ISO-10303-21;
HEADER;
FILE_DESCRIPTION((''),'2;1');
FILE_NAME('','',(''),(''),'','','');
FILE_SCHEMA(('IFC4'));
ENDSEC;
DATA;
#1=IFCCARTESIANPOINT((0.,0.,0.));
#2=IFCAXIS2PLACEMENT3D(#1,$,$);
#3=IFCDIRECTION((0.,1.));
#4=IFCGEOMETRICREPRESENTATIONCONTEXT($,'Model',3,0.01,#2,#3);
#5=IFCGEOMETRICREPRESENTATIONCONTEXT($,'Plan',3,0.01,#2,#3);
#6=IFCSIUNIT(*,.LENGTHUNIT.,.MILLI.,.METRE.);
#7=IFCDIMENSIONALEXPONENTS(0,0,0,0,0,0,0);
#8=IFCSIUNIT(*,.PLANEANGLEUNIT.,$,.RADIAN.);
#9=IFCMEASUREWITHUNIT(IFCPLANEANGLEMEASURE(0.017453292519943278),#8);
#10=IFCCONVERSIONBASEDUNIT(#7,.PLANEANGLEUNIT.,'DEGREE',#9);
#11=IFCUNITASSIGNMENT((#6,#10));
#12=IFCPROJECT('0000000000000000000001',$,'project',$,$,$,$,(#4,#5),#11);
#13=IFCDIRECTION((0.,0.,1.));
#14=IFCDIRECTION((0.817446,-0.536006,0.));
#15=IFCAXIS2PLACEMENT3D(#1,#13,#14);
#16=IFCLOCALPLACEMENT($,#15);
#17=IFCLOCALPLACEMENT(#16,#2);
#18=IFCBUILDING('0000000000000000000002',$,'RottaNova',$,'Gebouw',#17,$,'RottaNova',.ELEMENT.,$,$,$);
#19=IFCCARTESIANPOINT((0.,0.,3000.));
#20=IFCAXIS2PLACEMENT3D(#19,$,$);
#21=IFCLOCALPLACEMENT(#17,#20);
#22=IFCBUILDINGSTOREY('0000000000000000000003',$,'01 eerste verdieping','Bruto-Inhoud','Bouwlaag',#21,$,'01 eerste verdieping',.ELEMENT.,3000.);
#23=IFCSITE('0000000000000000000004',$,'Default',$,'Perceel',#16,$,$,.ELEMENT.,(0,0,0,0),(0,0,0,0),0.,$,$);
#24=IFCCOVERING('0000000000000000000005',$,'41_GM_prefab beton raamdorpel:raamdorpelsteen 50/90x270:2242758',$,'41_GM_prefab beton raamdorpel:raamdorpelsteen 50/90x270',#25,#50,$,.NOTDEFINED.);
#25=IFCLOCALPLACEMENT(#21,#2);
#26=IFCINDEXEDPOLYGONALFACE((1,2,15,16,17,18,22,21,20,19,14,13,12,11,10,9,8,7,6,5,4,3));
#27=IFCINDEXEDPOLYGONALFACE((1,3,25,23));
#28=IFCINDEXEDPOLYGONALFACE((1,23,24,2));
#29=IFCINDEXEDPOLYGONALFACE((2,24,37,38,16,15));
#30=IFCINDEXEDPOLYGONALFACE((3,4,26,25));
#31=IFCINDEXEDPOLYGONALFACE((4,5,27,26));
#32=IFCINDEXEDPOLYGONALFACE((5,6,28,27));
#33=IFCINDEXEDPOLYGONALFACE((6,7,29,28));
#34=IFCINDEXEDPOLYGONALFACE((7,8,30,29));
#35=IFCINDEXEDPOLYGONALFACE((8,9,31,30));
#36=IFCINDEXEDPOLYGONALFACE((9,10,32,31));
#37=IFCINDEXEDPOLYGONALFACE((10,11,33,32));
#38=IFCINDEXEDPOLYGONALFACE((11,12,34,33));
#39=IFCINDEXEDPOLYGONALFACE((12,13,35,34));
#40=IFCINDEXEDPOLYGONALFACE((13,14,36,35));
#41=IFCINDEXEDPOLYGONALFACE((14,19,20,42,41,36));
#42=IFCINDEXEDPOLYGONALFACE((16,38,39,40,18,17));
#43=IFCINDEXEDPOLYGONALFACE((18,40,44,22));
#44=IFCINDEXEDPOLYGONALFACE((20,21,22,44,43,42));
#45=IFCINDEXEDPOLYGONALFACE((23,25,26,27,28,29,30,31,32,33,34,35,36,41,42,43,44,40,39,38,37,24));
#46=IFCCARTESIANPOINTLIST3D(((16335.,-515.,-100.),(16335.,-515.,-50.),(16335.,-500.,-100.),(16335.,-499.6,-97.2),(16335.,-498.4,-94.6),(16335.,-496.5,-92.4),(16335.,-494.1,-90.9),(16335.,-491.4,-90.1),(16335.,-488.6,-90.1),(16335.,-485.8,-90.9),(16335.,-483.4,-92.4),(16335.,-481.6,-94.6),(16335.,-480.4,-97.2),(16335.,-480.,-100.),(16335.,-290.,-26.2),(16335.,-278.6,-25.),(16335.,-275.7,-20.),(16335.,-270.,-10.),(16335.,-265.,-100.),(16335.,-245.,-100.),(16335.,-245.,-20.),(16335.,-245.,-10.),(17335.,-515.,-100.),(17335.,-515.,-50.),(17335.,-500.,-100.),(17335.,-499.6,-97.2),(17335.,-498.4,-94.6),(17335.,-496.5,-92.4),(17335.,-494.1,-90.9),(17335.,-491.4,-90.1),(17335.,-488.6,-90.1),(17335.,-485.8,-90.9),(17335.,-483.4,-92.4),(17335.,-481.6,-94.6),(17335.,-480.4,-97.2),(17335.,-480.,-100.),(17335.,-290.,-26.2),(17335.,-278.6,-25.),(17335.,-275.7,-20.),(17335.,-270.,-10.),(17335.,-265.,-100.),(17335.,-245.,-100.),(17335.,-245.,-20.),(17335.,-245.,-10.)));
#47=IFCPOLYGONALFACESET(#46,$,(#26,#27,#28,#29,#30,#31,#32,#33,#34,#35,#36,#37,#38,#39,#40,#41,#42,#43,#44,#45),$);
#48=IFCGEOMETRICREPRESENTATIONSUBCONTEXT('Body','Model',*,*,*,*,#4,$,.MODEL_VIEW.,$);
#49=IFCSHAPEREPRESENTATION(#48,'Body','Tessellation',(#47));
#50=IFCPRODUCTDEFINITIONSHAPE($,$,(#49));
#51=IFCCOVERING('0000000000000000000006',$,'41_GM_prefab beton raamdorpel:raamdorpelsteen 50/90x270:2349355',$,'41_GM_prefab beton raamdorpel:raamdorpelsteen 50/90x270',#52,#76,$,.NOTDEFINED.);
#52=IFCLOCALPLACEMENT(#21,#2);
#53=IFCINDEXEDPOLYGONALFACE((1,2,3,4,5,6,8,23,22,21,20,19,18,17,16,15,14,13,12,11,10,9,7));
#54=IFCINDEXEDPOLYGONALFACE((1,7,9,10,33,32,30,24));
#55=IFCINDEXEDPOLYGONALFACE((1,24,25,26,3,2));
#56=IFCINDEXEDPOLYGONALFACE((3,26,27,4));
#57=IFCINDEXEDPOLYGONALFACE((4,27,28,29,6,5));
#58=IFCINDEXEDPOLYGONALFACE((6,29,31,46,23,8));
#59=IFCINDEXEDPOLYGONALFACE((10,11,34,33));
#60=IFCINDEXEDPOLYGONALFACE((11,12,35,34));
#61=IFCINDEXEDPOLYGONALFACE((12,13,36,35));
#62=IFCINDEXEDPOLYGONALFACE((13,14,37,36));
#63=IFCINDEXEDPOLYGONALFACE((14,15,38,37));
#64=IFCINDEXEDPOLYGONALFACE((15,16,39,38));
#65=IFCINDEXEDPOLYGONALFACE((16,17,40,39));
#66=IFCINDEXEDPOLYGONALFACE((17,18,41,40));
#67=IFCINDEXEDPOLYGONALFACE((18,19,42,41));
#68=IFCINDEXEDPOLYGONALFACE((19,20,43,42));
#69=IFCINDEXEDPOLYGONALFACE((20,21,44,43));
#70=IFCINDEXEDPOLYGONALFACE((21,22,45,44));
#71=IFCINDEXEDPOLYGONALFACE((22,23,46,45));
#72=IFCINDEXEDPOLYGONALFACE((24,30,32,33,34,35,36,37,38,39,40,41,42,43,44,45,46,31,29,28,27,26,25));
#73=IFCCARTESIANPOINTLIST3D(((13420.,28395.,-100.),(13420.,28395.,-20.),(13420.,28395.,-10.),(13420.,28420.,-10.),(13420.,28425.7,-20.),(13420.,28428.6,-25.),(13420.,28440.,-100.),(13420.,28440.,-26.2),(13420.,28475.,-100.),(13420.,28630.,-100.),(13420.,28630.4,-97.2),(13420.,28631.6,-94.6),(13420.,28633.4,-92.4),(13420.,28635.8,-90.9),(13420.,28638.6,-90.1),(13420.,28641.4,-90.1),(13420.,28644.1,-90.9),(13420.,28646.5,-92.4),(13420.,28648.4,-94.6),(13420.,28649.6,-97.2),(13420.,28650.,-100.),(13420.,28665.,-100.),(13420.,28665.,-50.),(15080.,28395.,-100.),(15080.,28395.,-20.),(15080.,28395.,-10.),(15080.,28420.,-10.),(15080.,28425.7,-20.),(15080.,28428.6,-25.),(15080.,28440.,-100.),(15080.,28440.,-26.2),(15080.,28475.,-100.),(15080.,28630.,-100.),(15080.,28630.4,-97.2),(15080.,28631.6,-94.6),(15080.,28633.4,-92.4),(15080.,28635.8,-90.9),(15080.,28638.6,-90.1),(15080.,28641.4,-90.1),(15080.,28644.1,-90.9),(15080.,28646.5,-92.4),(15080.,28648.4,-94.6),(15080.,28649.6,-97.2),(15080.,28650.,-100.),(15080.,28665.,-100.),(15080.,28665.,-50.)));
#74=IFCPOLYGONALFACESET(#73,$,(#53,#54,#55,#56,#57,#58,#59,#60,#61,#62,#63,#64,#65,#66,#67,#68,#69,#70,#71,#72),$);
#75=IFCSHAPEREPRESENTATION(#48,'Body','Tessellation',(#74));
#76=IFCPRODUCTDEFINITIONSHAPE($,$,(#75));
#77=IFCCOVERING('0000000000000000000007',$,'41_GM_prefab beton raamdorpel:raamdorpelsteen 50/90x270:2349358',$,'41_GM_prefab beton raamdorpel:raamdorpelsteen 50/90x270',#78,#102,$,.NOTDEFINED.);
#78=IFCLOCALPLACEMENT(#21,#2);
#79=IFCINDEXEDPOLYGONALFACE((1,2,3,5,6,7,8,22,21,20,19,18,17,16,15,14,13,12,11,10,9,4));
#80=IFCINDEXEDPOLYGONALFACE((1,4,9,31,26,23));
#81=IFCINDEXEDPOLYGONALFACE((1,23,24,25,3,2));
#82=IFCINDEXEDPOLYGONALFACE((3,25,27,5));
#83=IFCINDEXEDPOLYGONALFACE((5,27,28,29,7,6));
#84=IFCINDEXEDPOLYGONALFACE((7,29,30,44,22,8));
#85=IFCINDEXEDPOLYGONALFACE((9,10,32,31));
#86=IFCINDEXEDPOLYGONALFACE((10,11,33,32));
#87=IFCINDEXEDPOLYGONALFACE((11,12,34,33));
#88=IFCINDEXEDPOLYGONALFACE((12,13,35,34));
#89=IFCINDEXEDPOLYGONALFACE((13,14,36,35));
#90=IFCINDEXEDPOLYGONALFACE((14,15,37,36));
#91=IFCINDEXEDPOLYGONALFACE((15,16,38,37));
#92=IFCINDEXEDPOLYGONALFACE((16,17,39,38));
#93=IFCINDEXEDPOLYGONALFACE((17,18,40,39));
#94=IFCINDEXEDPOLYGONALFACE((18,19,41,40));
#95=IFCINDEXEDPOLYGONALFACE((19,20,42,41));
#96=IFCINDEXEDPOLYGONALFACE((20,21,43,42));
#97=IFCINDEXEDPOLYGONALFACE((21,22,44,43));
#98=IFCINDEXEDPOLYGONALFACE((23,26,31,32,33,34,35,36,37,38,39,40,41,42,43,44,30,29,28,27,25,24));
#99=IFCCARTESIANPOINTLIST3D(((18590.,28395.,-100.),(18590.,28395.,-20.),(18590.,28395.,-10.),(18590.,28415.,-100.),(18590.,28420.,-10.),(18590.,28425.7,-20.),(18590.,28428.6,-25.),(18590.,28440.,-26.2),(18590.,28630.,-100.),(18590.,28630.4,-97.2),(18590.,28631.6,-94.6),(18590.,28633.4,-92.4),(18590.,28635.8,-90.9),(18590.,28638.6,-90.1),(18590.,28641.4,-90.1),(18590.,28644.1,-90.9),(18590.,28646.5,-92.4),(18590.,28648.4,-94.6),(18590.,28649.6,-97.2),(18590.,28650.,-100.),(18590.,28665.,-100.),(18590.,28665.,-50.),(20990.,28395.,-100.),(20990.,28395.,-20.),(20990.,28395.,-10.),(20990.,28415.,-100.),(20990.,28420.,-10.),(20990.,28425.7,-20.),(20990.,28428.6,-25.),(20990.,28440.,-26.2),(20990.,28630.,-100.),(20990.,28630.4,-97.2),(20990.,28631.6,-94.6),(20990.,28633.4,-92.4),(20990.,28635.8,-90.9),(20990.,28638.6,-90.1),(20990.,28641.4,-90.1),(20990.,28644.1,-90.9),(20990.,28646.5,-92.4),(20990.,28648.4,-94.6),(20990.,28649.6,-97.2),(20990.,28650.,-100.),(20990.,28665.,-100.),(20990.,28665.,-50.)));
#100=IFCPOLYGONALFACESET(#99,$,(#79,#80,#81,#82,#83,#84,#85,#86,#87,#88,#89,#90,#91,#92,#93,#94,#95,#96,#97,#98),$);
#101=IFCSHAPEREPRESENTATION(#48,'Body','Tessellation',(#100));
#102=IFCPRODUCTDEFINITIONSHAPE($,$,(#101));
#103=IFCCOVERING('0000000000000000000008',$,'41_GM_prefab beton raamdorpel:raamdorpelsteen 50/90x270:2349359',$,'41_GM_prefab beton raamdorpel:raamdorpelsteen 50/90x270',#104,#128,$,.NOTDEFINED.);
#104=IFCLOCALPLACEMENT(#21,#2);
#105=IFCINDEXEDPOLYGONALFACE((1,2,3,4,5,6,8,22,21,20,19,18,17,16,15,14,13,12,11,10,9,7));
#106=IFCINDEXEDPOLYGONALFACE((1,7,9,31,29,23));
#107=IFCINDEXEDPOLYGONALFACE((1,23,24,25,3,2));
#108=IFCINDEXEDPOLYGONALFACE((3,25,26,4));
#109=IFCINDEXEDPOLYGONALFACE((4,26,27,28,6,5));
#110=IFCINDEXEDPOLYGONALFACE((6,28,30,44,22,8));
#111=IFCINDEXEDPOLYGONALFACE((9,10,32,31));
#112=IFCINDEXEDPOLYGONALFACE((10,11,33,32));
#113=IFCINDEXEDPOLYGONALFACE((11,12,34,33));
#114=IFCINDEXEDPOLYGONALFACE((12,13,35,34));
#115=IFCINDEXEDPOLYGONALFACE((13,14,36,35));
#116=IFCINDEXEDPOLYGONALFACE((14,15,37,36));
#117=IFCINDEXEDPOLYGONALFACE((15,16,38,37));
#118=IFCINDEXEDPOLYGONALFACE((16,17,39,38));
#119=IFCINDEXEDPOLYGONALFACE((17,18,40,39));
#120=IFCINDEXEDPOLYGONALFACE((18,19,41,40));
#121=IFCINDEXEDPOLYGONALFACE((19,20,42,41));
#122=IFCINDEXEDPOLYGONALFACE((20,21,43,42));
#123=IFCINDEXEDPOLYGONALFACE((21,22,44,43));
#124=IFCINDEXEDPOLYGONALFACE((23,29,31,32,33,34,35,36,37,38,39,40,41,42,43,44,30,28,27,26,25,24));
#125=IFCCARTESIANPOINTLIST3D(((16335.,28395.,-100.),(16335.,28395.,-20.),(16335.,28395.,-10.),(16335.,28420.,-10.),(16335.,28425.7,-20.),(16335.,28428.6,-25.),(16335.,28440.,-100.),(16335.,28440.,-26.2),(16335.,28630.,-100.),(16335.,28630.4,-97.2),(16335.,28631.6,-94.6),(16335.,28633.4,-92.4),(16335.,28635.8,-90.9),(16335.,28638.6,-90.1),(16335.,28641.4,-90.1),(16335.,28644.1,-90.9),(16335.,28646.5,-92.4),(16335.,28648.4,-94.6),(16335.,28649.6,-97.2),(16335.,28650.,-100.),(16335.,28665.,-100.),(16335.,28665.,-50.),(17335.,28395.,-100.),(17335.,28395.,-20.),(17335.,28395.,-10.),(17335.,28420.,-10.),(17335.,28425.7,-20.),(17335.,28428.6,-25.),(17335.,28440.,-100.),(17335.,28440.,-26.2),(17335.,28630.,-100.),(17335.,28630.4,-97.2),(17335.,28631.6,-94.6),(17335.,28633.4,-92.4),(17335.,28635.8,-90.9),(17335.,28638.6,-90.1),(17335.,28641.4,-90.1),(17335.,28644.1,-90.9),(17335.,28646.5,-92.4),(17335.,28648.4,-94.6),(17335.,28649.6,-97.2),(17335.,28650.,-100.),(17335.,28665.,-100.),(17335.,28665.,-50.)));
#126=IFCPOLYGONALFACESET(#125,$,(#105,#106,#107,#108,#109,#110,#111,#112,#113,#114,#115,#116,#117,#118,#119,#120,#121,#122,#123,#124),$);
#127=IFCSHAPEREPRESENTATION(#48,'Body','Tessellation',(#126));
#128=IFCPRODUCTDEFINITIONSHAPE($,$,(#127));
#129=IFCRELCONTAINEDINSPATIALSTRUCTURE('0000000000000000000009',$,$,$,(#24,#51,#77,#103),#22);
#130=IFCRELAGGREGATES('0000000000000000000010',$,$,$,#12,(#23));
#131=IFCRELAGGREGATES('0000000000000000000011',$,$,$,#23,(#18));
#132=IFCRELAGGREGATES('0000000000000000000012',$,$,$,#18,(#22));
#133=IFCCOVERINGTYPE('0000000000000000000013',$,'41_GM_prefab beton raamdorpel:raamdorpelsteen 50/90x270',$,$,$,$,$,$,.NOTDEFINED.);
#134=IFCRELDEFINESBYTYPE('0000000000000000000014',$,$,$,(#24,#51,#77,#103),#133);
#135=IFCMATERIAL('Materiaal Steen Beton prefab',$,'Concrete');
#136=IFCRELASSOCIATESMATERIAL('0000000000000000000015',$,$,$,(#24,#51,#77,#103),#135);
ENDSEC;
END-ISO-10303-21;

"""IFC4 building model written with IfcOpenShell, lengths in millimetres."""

from ifc_helpers import new_model, entity, si_unit, converted_unit, direction, frame, origin, place, context, subcontext, project, spatial, line, arc, indexed_curve, outline, extrude, material, type_object, element, save


model = new_model("IFC4")

# Units and contexts
model_context = context("Model", 3, precision=0.01, world=origin(), true_north=direction((0.0, 1.0)))
plan_context = context("Plan", 3, precision=0.01, world=origin(), true_north=direction((0.0, 1.0)))
body_context = subcontext(model_context, "Body", "Model", "MODEL_VIEW")
ifc_project = project(units=[si_unit("LENGTHUNIT", "METRE", prefix="MILLI"), converted_unit("PLANEANGLEUNIT", "DEGREE", entity("IfcPlaneAngleMeasure", 0.017453292519943278), si_unit("PLANEANGLEUNIT", "RADIAN"), dimensions=[0, 0, 0, 0, 0, 0, 0])], contexts=[model_context, plan_context])

# Site, building, storey
site_placement = place(None, frame((0.0, 0.0, 0.0), z_axis=(0.0, 0.0, 1.0), x_axis=(0.817446, -0.536006, 0.0)))
site = spatial("IfcSite", under=ifc_project, at=site_placement, Name="Default", ObjectType="Perceel", CompositionType="ELEMENT", RefLatitude=(0, 0, 0, 0), RefLongitude=(0, 0, 0, 0), RefElevation=0.0)
building_placement = place(site_placement, origin())
building = spatial("IfcBuilding", under=site, at=building_placement, Name="RottaNova", ObjectType="Gebouw", LongName="RottaNova", CompositionType="ELEMENT")
storey_placement = place(building_placement, frame((0.0, 0.0, 3000.0)))
storey = spatial("IfcBuildingStorey", under=building, at=storey_placement, Name="01 eerste verdieping", Description="Bruto-Inhoud", ObjectType="Bouwlaag", LongName="01 eerste verdieping", CompositionType="ELEMENT", Elevation=3000.0)

# Shared definitions
ifc_material_1 = material(Name="Materiaal Steen Beton prefab", Category="Concrete")

# Coverings
covering_type_1 = type_object("IfcCoveringType", Name="41_GM_prefab beton raamdorpel:raamdorpelsteen 50/90x270", PredefinedType="NOTDEFINED")
covering_1_placement = place(storey_placement, origin())
element("IfcCovering", 1, at=covering_1_placement, inside=storey, type_object=covering_type_1, material=ifc_material_1, Name="41_GM_prefab beton raamdorpel:raamdorpelsteen 50/90x270:2242758", ObjectType="41_GM_prefab beton raamdorpel:raamdorpelsteen 50/90x270", PredefinedType="NOTDEFINED", context=body_context, shape_type="SweptSolid", body=[
    extrude(outline(indexed_curve([(-75.9, -41.3), (-88.4, -62.9), (-79.8, -67.9), (-10.5, -107.9), (-0.5, -90.6), (107.0, 95.6), (103.4, 109.3), (117.0, 112.9), (124.5, 125.9), (81.2, 150.9), (-51.9, -32.0), (-58.6, -41.3), (-64.4, -41.3)], segments=[line(1, 2, 3, 4, 5, 6), arc(6, 7, 8), line(8, 9, 10, 11, 12, 13, 1)], self_intersect=False)), frame((16335.0, -343.7, -55.1), z_axis=(-1.0, 0.0, 0.0), x_axis=(0.0, -0.5, -0.866025)), (0.0, 0.0, -1.0), 1000.0),
])
covering_2_placement = place(storey_placement, origin())
element("IfcCovering", 2, at=covering_2_placement, inside=storey, type_object=covering_type_1, material=ifc_material_1, Name="41_GM_prefab beton raamdorpel:raamdorpelsteen 50/90x270:2349355", ObjectType="41_GM_prefab beton raamdorpel:raamdorpelsteen 50/90x270", PredefinedType="NOTDEFINED", context=body_context, shape_type="SweptSolid", body=[
    extrude(outline(indexed_curve([(74.2, -48.6), (99.2, -48.6), (99.2, -38.6), (99.2, 41.4), (54.2, 41.4), (19.2, 41.4), (-135.8, 41.4), (-145.8, 31.4), (-155.8, 41.4), (-170.8, 41.4), (-170.8, -8.6), (54.2, -32.4), (65.5, -33.6), (68.4, -38.6)], segments=[line(1, 2, 3, 4, 5, 6, 7), arc(7, 8, 9), line(9, 10, 11, 12, 13, 14, 1)], self_intersect=False)), frame((13420.0, 28494.2, -58.6), z_axis=(1.0, 0.0, 0.0), x_axis=(0.0, -1.0, 0.0)), (0.0, 0.0, 1.0), 1660.0),
])
covering_3_placement = place(storey_placement, origin())
element("IfcCovering", 3, at=covering_3_placement, inside=storey, type_object=covering_type_1, material=ifc_material_1, Name="41_GM_prefab beton raamdorpel:raamdorpelsteen 50/90x270:2349358", ObjectType="41_GM_prefab beton raamdorpel:raamdorpelsteen 50/90x270", PredefinedType="NOTDEFINED", context=body_context, shape_type="SweptSolid", body=[
    extrude(outline(indexed_curve([(73.7, -45.1), (98.7, -45.1), (98.7, -35.1), (98.7, 44.9), (78.7, 44.9), (-136.3, 44.9), (-146.3, 34.9), (-156.3, 44.9), (-171.3, 44.9), (-171.3, -5.1), (53.7, -28.9), (65.0, -30.1), (67.9, -35.1)], segments=[line(1, 2, 3, 4, 5, 6), arc(6, 7, 8), line(8, 9, 10, 11, 12, 13, 1)], self_intersect=False)), frame((18590.0, 28493.7, -55.1), z_axis=(1.0, 0.0, 0.0), x_axis=(0.0, -1.0, 0.0)), (0.0, 0.0, 1.0), 2400.0),
])
covering_4_placement = place(storey_placement, origin())
element("IfcCovering", 4, at=covering_4_placement, inside=storey, type_object=covering_type_1, material=ifc_material_1, Name="41_GM_prefab beton raamdorpel:raamdorpelsteen 50/90x270:2349359", ObjectType="41_GM_prefab beton raamdorpel:raamdorpelsteen 50/90x270", PredefinedType="NOTDEFINED", context=body_context, shape_type="SweptSolid", body=[
    extrude(outline(indexed_curve([(75.8, -45.1), (100.8, -45.1), (100.8, -35.1), (100.8, 44.9), (55.8, 44.9), (-134.2, 44.9), (-144.2, 34.9), (-154.2, 44.9), (-169.2, 44.9), (-169.2, -5.1), (55.8, -28.9), (67.1, -30.1), (70.0, -35.1)], segments=[line(1, 2, 3, 4, 5, 6), arc(6, 7, 8), line(8, 9, 10, 11, 12, 13, 1)], self_intersect=False)), frame((16335.0, 28495.8, -55.1), z_axis=(1.0, 0.0, 0.0), x_axis=(0.0, -1.0, 0.0)), (0.0, 0.0, 1.0), 1000.0),
])

save(model, "model.ifc")
